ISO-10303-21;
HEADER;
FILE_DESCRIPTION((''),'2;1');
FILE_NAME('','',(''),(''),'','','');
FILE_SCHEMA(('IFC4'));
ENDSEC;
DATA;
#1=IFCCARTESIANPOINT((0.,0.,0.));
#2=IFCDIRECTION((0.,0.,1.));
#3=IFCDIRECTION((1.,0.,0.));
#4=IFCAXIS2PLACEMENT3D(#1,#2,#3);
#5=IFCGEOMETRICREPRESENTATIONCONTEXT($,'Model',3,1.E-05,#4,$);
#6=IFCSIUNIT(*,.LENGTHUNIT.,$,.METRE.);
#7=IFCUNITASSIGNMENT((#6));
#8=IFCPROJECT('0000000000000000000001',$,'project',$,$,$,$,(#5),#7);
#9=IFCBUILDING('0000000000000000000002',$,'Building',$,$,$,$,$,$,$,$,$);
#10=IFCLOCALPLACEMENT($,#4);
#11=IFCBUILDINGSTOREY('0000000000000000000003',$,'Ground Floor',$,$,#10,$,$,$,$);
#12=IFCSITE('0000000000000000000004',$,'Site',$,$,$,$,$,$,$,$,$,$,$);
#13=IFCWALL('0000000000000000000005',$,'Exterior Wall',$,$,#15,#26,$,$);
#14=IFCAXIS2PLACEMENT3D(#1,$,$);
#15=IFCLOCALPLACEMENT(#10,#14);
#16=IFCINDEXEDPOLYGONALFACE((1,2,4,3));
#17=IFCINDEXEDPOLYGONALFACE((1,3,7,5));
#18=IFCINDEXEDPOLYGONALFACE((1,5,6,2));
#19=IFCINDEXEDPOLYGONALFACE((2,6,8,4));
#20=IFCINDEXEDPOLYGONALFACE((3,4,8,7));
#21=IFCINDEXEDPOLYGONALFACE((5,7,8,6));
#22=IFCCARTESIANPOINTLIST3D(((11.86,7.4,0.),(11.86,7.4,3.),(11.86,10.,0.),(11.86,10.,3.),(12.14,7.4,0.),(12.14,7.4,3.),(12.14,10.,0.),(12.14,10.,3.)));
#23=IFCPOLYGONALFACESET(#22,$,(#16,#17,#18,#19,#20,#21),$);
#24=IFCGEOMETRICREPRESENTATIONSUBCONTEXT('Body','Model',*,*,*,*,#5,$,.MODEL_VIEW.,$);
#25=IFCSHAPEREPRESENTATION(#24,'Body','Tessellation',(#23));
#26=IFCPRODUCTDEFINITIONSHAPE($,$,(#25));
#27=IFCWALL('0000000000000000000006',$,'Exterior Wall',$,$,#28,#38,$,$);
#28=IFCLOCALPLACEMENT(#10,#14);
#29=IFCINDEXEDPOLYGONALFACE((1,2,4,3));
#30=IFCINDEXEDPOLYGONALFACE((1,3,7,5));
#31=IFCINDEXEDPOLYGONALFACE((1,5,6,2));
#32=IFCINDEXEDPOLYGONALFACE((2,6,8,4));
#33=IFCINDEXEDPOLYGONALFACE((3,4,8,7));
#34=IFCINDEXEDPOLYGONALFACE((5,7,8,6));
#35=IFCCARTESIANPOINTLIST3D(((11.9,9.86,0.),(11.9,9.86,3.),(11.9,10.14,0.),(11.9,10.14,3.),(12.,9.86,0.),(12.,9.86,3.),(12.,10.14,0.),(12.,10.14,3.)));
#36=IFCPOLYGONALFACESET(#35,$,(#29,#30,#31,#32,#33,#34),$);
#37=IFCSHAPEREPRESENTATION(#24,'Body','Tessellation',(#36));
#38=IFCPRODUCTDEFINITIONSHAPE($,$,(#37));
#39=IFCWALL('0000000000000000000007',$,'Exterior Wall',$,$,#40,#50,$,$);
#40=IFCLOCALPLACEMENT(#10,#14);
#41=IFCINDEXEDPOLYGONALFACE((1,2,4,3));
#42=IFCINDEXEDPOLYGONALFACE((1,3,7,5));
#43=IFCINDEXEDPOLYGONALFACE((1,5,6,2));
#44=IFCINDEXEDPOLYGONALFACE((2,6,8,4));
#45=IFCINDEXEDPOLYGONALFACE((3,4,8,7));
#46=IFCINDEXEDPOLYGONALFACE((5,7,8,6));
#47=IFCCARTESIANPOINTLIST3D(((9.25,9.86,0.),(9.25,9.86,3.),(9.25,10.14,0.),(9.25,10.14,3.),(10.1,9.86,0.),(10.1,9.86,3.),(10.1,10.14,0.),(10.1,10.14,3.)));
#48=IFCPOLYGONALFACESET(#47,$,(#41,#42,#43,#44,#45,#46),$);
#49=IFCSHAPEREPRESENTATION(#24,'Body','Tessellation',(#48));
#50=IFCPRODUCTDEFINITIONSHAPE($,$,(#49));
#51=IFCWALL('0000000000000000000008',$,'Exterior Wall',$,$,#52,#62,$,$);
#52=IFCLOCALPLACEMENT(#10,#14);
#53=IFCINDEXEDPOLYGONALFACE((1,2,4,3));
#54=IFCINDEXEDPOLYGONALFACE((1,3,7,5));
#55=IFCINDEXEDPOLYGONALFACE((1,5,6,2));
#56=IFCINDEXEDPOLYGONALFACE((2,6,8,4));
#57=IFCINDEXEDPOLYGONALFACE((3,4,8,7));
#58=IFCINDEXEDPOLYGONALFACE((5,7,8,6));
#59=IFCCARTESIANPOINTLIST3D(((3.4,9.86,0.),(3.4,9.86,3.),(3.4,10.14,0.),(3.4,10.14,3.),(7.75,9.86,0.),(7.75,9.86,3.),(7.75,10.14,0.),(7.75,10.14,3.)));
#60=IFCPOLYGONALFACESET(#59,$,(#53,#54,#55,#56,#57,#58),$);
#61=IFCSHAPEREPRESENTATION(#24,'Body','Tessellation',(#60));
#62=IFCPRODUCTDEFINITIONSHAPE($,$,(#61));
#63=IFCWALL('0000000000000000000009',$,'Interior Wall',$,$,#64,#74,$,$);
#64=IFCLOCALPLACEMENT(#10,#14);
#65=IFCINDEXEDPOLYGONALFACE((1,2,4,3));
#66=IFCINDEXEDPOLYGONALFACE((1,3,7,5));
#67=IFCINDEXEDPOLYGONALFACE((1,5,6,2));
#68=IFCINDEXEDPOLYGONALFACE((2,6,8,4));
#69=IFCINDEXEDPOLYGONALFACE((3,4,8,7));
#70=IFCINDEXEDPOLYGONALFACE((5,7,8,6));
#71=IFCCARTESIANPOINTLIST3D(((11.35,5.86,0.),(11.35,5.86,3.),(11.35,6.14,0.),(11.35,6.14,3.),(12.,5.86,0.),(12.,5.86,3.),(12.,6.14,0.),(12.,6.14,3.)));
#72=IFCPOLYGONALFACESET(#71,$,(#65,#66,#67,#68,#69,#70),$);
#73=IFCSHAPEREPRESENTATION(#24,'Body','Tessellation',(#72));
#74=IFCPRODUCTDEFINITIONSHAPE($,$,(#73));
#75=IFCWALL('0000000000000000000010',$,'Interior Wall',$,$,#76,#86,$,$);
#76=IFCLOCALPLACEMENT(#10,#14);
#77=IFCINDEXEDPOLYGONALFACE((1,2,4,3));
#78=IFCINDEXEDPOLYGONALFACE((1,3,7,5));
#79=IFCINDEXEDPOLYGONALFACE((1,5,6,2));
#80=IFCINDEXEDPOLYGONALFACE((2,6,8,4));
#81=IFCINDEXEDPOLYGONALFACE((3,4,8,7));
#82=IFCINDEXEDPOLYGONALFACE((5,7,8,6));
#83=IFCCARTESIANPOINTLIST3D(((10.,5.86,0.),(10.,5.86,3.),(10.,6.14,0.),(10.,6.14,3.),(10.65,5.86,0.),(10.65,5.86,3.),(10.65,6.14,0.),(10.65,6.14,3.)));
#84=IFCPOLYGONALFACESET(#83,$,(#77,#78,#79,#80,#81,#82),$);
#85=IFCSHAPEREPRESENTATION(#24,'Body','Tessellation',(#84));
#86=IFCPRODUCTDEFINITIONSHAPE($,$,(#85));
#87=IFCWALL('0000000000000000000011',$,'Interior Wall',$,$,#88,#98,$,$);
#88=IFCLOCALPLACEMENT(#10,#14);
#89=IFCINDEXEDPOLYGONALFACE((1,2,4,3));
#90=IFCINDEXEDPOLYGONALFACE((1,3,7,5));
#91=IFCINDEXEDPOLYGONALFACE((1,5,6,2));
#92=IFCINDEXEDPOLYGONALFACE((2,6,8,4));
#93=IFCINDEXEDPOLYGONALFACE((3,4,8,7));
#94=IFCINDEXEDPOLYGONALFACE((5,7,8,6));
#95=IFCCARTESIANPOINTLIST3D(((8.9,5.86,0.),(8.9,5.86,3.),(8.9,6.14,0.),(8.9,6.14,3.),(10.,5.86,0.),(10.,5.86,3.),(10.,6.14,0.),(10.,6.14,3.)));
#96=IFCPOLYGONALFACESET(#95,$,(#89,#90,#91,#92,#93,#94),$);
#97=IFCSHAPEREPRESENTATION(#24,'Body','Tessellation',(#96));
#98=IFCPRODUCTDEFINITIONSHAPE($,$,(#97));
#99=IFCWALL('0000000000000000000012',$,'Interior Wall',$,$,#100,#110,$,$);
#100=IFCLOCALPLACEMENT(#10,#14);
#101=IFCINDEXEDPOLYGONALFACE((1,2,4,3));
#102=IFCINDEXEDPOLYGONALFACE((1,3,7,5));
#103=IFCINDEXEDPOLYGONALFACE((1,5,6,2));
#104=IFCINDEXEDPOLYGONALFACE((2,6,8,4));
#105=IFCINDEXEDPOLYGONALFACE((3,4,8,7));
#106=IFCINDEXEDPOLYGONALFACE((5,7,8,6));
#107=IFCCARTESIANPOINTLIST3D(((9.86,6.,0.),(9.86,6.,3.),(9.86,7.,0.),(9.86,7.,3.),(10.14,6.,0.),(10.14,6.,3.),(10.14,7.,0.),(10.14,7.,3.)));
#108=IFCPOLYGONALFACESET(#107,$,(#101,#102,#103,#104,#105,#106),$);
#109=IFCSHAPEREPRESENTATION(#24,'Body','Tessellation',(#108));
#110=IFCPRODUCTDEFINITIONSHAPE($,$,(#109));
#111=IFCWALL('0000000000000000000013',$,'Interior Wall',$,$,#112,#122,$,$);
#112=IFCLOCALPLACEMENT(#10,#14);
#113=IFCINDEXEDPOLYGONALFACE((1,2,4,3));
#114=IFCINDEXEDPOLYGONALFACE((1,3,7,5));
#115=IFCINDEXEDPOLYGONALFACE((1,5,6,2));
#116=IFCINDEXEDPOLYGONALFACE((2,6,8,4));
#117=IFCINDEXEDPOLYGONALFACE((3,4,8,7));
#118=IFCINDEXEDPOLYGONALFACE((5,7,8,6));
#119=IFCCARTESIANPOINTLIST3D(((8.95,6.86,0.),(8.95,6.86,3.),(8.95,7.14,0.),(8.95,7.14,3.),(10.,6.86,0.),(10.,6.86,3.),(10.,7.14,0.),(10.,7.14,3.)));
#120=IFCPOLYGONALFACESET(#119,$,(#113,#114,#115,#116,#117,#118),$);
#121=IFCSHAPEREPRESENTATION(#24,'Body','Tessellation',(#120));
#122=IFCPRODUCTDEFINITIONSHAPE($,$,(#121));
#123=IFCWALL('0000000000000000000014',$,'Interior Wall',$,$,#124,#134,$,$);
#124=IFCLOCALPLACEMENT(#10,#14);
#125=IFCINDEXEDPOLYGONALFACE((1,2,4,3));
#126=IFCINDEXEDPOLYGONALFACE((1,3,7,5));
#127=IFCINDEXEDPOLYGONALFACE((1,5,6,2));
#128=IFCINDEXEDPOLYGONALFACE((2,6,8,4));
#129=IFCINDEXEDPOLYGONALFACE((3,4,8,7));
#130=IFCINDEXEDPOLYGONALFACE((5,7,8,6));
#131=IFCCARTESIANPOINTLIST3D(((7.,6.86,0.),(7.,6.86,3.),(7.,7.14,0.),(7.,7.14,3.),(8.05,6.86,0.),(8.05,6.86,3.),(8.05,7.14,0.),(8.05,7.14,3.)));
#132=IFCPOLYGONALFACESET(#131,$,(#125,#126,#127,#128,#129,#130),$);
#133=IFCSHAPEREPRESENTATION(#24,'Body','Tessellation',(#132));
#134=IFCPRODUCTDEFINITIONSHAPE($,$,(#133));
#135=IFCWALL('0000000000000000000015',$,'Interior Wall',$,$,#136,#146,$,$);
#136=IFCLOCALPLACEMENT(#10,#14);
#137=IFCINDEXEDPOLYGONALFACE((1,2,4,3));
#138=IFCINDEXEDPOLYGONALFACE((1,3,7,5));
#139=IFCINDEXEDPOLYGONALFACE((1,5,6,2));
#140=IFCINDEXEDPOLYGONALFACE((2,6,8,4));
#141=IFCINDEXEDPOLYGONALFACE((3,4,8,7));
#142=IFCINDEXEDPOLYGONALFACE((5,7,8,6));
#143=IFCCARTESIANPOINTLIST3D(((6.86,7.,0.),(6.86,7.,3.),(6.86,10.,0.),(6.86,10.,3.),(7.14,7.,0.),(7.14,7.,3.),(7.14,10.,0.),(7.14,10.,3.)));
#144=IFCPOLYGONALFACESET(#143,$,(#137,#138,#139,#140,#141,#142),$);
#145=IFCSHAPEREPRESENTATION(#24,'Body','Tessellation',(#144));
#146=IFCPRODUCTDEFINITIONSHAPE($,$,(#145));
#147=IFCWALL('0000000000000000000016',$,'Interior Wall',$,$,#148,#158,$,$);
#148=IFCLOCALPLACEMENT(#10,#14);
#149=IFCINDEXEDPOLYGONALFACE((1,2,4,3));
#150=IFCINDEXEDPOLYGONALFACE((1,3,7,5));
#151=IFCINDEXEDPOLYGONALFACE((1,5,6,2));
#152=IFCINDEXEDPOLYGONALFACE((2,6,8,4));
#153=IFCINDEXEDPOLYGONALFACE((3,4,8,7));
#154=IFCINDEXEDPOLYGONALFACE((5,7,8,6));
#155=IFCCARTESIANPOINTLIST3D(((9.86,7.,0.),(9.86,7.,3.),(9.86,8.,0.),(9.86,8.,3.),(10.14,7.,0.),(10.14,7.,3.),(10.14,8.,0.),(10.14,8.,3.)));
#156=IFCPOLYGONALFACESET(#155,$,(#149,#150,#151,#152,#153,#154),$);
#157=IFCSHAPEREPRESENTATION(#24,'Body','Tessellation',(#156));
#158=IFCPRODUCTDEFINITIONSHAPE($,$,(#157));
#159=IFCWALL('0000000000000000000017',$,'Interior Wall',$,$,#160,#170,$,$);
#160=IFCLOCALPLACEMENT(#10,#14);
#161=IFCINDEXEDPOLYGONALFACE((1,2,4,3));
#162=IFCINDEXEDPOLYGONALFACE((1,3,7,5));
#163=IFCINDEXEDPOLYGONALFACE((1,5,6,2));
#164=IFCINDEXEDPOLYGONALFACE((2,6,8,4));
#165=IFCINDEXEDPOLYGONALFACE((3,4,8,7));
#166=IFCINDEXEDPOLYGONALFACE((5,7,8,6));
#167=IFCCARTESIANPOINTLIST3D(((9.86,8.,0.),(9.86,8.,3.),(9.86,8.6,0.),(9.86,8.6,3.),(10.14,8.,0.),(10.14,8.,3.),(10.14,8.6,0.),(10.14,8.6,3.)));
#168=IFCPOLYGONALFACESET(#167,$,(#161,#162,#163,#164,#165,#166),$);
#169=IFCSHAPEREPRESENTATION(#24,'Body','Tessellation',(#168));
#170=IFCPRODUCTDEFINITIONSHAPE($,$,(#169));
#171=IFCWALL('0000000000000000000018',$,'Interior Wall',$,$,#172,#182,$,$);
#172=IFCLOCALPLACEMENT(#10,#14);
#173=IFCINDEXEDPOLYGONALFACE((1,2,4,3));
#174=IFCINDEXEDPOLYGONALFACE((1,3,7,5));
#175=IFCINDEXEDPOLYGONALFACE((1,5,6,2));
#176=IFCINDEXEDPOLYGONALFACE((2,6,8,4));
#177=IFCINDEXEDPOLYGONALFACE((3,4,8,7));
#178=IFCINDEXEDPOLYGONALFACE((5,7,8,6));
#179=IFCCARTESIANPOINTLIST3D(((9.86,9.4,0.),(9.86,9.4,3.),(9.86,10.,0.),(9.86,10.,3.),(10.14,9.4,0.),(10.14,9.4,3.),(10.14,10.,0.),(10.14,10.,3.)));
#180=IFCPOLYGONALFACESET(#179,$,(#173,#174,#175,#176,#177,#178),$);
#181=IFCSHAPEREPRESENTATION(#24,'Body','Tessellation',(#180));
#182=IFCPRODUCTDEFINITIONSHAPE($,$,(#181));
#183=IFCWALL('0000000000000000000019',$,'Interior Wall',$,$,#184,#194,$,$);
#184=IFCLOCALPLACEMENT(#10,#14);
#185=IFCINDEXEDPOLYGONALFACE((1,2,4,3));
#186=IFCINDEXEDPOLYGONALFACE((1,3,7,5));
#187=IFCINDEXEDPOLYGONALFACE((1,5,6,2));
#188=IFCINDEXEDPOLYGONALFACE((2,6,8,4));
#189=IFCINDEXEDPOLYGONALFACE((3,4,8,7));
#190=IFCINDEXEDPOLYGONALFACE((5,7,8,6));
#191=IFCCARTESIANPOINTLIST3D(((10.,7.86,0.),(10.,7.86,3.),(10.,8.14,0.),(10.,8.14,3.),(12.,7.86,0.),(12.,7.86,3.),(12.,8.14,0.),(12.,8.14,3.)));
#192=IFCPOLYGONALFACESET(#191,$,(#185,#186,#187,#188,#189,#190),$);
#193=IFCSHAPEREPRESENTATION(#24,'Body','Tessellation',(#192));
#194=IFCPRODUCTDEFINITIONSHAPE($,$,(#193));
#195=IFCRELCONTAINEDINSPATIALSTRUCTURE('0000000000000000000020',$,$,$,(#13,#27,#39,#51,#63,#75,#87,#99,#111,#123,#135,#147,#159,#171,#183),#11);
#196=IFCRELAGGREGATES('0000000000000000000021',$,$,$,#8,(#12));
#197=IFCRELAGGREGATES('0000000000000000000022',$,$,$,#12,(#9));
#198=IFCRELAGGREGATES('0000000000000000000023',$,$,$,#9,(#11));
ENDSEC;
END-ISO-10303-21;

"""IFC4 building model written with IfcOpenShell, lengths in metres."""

from ifc_helpers import new_model, si_unit, frame, origin_with_axes, place, context, subcontext, project, spatial, indexed_curve, outline, extrude, element, save


model = new_model("IFC4")

# Units and contexts
model_context = context("Model", 3, precision=1e-05, world=origin_with_axes())
body_context = subcontext(model_context, "Body", "Model", "MODEL_VIEW")
ifc_project = project(units=[si_unit("LENGTHUNIT", "METRE")], contexts=[model_context])

# Site, building, storey
site = spatial("IfcSite", under=ifc_project, Name="Site")
building = spatial("IfcBuilding", under=site, Name="Building")
storey_placement = place(None, origin_with_axes())
storey = spatial("IfcBuildingStorey", under=building, at=storey_placement, Name="Ground Floor")

# Walls
wall_1_placement = place(storey_placement, frame((12.0, 7.4, 0.0), z_axis=(0.0, 0.0, 1.0), x_axis=(0.0, 1.0, 0.0)))
element("IfcWall", 1, at=wall_1_placement, inside=storey, Name="Exterior Wall", context=body_context, shape_type="SweptSolid", body=[
    extrude(outline(indexed_curve([(0.0, 0.0), (0.0, 0.28), (2.6, 0.28), (2.6, 0.0), (0.0, 0.0)], self_intersect=False)), frame((0.0, -0.14, 0.0), z_axis=(0.0, 0.0, 1.0), x_axis=(1.0, 0.0, 0.0)), (0.0, 0.0, 1.0), 3.0),
])
wall_2_placement = place(storey_placement, frame((12.0, 10.0, 0.0), z_axis=(0.0, 0.0, 1.0), x_axis=(-1.0, 0.0, 0.0)))
element("IfcWall", 2, at=wall_2_placement, inside=storey, Name="Exterior Wall", context=body_context, shape_type="SweptSolid", body=[
    extrude(outline(indexed_curve([(0.0, 0.0), (0.0, 0.28), (0.1, 0.28), (0.1, 0.0), (0.0, 0.0)], self_intersect=False)), frame((0.0, -0.14, 0.0), z_axis=(0.0, 0.0, 1.0), x_axis=(1.0, 0.0, 0.0)), (0.0, 0.0, 1.0), 3.0),
])
wall_3_placement = place(storey_placement, frame((10.1, 10.0, 0.0), z_axis=(0.0, 0.0, 1.0), x_axis=(-1.0, 0.0, 0.0)))
element("IfcWall", 3, at=wall_3_placement, inside=storey, Name="Exterior Wall", context=body_context, shape_type="SweptSolid", body=[
    extrude(outline(indexed_curve([(0.0, 0.0), (0.0, 0.28), (0.85, 0.28), (0.85, 0.0), (0.0, 0.0)], self_intersect=False)), frame((0.0, -0.14, 0.0), z_axis=(0.0, 0.0, 1.0), x_axis=(1.0, 0.0, 0.0)), (0.0, 0.0, 1.0), 3.0),
])
wall_4_placement = place(storey_placement, frame((7.75, 10.0, 0.0), z_axis=(0.0, 0.0, 1.0), x_axis=(-1.0, 0.0, 0.0)))
element("IfcWall", 4, at=wall_4_placement, inside=storey, Name="Exterior Wall", context=body_context, shape_type="SweptSolid", body=[
    extrude(outline(indexed_curve([(0.0, 0.0), (0.0, 0.28), (4.35, 0.28), (4.35, 0.0), (0.0, 0.0)], self_intersect=False)), frame((0.0, -0.14, 0.0), z_axis=(0.0, 0.0, 1.0), x_axis=(1.0, 0.0, 0.0)), (0.0, 0.0, 1.0), 3.0),
])
for number, where, z_axis, x_axis, name in (
    (5, (12.0, 6.0, 0.0), (0.0, 0.0, 1.0), (-1.0, 0.0, 0.0), "Interior Wall"),
    (6, (10.65, 6.0, 0.0), (0.0, 0.0, 1.0), (-1.0, 0.0, 0.0), "Interior Wall"),
):
    element("IfcWall", number, at=place(storey_placement, frame(where, z_axis=z_axis, x_axis=x_axis)), inside=storey, Name=name, context=body_context, shape_type="SweptSolid", body=[
        extrude(outline(indexed_curve([(0.0, 0.0), (0.0, 0.28), (0.65, 0.28), (0.65, 0.0), (0.0, 0.0)], self_intersect=False)), frame((0.0, -0.14, 0.0), z_axis=(0.0, 0.0, 1.0), x_axis=(1.0, 0.0, 0.0)), (0.0, 0.0, 1.0), 3.0),
    ])
wall_5_placement = place(storey_placement, frame((10.0, 6.0, 0.0), z_axis=(0.0, 0.0, 1.0), x_axis=(-1.0, 0.0, 0.0)))
element("IfcWall", 7, at=wall_5_placement, inside=storey, Name="Interior Wall", context=body_context, shape_type="SweptSolid", body=[
    extrude(outline(indexed_curve([(0.0, 0.0), (0.0, 0.28), (1.1, 0.28), (1.1, 0.0), (0.0, 0.0)], self_intersect=False)), frame((0.0, -0.14, 0.0), z_axis=(0.0, 0.0, 1.0), x_axis=(1.0, 0.0, 0.0)), (0.0, 0.0, 1.0), 3.0),
])
wall_6_placement = place(storey_placement, frame((10.0, 6.0, 0.0), z_axis=(0.0, 0.0, 1.0), x_axis=(0.0, 1.0, 0.0)))
element("IfcWall", 8, at=wall_6_placement, inside=storey, Name="Interior Wall", context=body_context, shape_type="SweptSolid", body=[
    extrude(outline(indexed_curve([(0.0, 0.0), (0.0, 0.28), (1.0, 0.28), (1.0, 0.0), (0.0, 0.0)], self_intersect=False)), frame((0.0, -0.14, 0.0), z_axis=(0.0, 0.0, 1.0), x_axis=(1.0, 0.0, 0.0)), (0.0, 0.0, 1.0), 3.0),
])
for number, where, z_axis, x_axis, name in (
    (9, (10.0, 7.0, 0.0), (0.0, 0.0, 1.0), (-1.0, 0.0, 0.0), "Interior Wall"),
    (10, (8.05, 7.0, 0.0), (0.0, 0.0, 1.0), (-1.0, 0.0, 0.0), "Interior Wall"),
):
    element("IfcWall", number, at=place(storey_placement, frame(where, z_axis=z_axis, x_axis=x_axis)), inside=storey, Name=name, context=body_context, shape_type="SweptSolid", body=[
        extrude(outline(indexed_curve([(0.0, 0.0), (0.0, 0.28), (1.05, 0.28), (1.05, 0.0), (0.0, 0.0)], self_intersect=False)), frame((0.0, -0.14, 0.0), z_axis=(0.0, 0.0, 1.0), x_axis=(1.0, 0.0, 0.0)), (0.0, 0.0, 1.0), 3.0),
    ])
wall_7_placement = place(storey_placement, frame((7.0, 7.0, 0.0), z_axis=(0.0, 0.0, 1.0), x_axis=(0.0, 1.0, 0.0)))
element("IfcWall", 11, at=wall_7_placement, inside=storey, Name="Interior Wall", context=body_context, shape_type="SweptSolid", body=[
    extrude(outline(indexed_curve([(0.0, 0.0), (0.0, 0.28), (3.0, 0.28), (3.0, 0.0), (0.0, 0.0)], self_intersect=False)), frame((0.0, -0.14, 0.0), z_axis=(0.0, 0.0, 1.0), x_axis=(1.0, 0.0, 0.0)), (0.0, 0.0, 1.0), 3.0),
])
wall_8_placement = place(storey_placement, frame((10.0, 7.0, 0.0), z_axis=(0.0, 0.0, 1.0), x_axis=(0.0, 1.0, 0.0)))
element("IfcWall", 12, at=wall_8_placement, inside=storey, Name="Interior Wall", context=body_context, shape_type="SweptSolid", body=[
    extrude(outline(indexed_curve([(0.0, 0.0), (0.0, 0.28), (1.0, 0.28), (1.0, 0.0), (0.0, 0.0)], self_intersect=False)), frame((0.0, -0.14, 0.0), z_axis=(0.0, 0.0, 1.0), x_axis=(1.0, 0.0, 0.0)), (0.0, 0.0, 1.0), 3.0),
])
for number, where, z_axis, x_axis, name in (
    (13, (10.0, 8.0, 0.0), (0.0, 0.0, 1.0), (0.0, 1.0, 0.0), "Interior Wall"),
    (14, (10.0, 9.4, 0.0), (0.0, 0.0, 1.0), (0.0, 1.0, 0.0), "Interior Wall"),
):
    element("IfcWall", number, at=place(storey_placement, frame(where, z_axis=z_axis, x_axis=x_axis)), inside=storey, Name=name, context=body_context, shape_type="SweptSolid", body=[
        extrude(outline(indexed_curve([(0.0, 0.0), (0.0, 0.28), (0.6, 0.28), (0.6, 0.0), (0.0, 0.0)], self_intersect=False)), frame((0.0, -0.14, 0.0), z_axis=(0.0, 0.0, 1.0), x_axis=(1.0, 0.0, 0.0)), (0.0, 0.0, 1.0), 3.0),
    ])
wall_9_placement = place(storey_placement, frame((12.0, 8.0, 0.0), z_axis=(0.0, 0.0, 1.0), x_axis=(-1.0, 0.0, 0.0)))
element("IfcWall", 15, at=wall_9_placement, inside=storey, Name="Interior Wall", context=body_context, shape_type="SweptSolid", body=[
    extrude(outline(indexed_curve([(0.0, 0.0), (0.0, 0.28), (2.0, 0.28), (2.0, 0.0), (0.0, 0.0)], self_intersect=False)), frame((0.0, -0.14, 0.0), z_axis=(0.0, 0.0, 1.0), x_axis=(1.0, 0.0, 0.0)), (0.0, 0.0, 1.0), 3.0),
])

save(model, "model.ifc")
